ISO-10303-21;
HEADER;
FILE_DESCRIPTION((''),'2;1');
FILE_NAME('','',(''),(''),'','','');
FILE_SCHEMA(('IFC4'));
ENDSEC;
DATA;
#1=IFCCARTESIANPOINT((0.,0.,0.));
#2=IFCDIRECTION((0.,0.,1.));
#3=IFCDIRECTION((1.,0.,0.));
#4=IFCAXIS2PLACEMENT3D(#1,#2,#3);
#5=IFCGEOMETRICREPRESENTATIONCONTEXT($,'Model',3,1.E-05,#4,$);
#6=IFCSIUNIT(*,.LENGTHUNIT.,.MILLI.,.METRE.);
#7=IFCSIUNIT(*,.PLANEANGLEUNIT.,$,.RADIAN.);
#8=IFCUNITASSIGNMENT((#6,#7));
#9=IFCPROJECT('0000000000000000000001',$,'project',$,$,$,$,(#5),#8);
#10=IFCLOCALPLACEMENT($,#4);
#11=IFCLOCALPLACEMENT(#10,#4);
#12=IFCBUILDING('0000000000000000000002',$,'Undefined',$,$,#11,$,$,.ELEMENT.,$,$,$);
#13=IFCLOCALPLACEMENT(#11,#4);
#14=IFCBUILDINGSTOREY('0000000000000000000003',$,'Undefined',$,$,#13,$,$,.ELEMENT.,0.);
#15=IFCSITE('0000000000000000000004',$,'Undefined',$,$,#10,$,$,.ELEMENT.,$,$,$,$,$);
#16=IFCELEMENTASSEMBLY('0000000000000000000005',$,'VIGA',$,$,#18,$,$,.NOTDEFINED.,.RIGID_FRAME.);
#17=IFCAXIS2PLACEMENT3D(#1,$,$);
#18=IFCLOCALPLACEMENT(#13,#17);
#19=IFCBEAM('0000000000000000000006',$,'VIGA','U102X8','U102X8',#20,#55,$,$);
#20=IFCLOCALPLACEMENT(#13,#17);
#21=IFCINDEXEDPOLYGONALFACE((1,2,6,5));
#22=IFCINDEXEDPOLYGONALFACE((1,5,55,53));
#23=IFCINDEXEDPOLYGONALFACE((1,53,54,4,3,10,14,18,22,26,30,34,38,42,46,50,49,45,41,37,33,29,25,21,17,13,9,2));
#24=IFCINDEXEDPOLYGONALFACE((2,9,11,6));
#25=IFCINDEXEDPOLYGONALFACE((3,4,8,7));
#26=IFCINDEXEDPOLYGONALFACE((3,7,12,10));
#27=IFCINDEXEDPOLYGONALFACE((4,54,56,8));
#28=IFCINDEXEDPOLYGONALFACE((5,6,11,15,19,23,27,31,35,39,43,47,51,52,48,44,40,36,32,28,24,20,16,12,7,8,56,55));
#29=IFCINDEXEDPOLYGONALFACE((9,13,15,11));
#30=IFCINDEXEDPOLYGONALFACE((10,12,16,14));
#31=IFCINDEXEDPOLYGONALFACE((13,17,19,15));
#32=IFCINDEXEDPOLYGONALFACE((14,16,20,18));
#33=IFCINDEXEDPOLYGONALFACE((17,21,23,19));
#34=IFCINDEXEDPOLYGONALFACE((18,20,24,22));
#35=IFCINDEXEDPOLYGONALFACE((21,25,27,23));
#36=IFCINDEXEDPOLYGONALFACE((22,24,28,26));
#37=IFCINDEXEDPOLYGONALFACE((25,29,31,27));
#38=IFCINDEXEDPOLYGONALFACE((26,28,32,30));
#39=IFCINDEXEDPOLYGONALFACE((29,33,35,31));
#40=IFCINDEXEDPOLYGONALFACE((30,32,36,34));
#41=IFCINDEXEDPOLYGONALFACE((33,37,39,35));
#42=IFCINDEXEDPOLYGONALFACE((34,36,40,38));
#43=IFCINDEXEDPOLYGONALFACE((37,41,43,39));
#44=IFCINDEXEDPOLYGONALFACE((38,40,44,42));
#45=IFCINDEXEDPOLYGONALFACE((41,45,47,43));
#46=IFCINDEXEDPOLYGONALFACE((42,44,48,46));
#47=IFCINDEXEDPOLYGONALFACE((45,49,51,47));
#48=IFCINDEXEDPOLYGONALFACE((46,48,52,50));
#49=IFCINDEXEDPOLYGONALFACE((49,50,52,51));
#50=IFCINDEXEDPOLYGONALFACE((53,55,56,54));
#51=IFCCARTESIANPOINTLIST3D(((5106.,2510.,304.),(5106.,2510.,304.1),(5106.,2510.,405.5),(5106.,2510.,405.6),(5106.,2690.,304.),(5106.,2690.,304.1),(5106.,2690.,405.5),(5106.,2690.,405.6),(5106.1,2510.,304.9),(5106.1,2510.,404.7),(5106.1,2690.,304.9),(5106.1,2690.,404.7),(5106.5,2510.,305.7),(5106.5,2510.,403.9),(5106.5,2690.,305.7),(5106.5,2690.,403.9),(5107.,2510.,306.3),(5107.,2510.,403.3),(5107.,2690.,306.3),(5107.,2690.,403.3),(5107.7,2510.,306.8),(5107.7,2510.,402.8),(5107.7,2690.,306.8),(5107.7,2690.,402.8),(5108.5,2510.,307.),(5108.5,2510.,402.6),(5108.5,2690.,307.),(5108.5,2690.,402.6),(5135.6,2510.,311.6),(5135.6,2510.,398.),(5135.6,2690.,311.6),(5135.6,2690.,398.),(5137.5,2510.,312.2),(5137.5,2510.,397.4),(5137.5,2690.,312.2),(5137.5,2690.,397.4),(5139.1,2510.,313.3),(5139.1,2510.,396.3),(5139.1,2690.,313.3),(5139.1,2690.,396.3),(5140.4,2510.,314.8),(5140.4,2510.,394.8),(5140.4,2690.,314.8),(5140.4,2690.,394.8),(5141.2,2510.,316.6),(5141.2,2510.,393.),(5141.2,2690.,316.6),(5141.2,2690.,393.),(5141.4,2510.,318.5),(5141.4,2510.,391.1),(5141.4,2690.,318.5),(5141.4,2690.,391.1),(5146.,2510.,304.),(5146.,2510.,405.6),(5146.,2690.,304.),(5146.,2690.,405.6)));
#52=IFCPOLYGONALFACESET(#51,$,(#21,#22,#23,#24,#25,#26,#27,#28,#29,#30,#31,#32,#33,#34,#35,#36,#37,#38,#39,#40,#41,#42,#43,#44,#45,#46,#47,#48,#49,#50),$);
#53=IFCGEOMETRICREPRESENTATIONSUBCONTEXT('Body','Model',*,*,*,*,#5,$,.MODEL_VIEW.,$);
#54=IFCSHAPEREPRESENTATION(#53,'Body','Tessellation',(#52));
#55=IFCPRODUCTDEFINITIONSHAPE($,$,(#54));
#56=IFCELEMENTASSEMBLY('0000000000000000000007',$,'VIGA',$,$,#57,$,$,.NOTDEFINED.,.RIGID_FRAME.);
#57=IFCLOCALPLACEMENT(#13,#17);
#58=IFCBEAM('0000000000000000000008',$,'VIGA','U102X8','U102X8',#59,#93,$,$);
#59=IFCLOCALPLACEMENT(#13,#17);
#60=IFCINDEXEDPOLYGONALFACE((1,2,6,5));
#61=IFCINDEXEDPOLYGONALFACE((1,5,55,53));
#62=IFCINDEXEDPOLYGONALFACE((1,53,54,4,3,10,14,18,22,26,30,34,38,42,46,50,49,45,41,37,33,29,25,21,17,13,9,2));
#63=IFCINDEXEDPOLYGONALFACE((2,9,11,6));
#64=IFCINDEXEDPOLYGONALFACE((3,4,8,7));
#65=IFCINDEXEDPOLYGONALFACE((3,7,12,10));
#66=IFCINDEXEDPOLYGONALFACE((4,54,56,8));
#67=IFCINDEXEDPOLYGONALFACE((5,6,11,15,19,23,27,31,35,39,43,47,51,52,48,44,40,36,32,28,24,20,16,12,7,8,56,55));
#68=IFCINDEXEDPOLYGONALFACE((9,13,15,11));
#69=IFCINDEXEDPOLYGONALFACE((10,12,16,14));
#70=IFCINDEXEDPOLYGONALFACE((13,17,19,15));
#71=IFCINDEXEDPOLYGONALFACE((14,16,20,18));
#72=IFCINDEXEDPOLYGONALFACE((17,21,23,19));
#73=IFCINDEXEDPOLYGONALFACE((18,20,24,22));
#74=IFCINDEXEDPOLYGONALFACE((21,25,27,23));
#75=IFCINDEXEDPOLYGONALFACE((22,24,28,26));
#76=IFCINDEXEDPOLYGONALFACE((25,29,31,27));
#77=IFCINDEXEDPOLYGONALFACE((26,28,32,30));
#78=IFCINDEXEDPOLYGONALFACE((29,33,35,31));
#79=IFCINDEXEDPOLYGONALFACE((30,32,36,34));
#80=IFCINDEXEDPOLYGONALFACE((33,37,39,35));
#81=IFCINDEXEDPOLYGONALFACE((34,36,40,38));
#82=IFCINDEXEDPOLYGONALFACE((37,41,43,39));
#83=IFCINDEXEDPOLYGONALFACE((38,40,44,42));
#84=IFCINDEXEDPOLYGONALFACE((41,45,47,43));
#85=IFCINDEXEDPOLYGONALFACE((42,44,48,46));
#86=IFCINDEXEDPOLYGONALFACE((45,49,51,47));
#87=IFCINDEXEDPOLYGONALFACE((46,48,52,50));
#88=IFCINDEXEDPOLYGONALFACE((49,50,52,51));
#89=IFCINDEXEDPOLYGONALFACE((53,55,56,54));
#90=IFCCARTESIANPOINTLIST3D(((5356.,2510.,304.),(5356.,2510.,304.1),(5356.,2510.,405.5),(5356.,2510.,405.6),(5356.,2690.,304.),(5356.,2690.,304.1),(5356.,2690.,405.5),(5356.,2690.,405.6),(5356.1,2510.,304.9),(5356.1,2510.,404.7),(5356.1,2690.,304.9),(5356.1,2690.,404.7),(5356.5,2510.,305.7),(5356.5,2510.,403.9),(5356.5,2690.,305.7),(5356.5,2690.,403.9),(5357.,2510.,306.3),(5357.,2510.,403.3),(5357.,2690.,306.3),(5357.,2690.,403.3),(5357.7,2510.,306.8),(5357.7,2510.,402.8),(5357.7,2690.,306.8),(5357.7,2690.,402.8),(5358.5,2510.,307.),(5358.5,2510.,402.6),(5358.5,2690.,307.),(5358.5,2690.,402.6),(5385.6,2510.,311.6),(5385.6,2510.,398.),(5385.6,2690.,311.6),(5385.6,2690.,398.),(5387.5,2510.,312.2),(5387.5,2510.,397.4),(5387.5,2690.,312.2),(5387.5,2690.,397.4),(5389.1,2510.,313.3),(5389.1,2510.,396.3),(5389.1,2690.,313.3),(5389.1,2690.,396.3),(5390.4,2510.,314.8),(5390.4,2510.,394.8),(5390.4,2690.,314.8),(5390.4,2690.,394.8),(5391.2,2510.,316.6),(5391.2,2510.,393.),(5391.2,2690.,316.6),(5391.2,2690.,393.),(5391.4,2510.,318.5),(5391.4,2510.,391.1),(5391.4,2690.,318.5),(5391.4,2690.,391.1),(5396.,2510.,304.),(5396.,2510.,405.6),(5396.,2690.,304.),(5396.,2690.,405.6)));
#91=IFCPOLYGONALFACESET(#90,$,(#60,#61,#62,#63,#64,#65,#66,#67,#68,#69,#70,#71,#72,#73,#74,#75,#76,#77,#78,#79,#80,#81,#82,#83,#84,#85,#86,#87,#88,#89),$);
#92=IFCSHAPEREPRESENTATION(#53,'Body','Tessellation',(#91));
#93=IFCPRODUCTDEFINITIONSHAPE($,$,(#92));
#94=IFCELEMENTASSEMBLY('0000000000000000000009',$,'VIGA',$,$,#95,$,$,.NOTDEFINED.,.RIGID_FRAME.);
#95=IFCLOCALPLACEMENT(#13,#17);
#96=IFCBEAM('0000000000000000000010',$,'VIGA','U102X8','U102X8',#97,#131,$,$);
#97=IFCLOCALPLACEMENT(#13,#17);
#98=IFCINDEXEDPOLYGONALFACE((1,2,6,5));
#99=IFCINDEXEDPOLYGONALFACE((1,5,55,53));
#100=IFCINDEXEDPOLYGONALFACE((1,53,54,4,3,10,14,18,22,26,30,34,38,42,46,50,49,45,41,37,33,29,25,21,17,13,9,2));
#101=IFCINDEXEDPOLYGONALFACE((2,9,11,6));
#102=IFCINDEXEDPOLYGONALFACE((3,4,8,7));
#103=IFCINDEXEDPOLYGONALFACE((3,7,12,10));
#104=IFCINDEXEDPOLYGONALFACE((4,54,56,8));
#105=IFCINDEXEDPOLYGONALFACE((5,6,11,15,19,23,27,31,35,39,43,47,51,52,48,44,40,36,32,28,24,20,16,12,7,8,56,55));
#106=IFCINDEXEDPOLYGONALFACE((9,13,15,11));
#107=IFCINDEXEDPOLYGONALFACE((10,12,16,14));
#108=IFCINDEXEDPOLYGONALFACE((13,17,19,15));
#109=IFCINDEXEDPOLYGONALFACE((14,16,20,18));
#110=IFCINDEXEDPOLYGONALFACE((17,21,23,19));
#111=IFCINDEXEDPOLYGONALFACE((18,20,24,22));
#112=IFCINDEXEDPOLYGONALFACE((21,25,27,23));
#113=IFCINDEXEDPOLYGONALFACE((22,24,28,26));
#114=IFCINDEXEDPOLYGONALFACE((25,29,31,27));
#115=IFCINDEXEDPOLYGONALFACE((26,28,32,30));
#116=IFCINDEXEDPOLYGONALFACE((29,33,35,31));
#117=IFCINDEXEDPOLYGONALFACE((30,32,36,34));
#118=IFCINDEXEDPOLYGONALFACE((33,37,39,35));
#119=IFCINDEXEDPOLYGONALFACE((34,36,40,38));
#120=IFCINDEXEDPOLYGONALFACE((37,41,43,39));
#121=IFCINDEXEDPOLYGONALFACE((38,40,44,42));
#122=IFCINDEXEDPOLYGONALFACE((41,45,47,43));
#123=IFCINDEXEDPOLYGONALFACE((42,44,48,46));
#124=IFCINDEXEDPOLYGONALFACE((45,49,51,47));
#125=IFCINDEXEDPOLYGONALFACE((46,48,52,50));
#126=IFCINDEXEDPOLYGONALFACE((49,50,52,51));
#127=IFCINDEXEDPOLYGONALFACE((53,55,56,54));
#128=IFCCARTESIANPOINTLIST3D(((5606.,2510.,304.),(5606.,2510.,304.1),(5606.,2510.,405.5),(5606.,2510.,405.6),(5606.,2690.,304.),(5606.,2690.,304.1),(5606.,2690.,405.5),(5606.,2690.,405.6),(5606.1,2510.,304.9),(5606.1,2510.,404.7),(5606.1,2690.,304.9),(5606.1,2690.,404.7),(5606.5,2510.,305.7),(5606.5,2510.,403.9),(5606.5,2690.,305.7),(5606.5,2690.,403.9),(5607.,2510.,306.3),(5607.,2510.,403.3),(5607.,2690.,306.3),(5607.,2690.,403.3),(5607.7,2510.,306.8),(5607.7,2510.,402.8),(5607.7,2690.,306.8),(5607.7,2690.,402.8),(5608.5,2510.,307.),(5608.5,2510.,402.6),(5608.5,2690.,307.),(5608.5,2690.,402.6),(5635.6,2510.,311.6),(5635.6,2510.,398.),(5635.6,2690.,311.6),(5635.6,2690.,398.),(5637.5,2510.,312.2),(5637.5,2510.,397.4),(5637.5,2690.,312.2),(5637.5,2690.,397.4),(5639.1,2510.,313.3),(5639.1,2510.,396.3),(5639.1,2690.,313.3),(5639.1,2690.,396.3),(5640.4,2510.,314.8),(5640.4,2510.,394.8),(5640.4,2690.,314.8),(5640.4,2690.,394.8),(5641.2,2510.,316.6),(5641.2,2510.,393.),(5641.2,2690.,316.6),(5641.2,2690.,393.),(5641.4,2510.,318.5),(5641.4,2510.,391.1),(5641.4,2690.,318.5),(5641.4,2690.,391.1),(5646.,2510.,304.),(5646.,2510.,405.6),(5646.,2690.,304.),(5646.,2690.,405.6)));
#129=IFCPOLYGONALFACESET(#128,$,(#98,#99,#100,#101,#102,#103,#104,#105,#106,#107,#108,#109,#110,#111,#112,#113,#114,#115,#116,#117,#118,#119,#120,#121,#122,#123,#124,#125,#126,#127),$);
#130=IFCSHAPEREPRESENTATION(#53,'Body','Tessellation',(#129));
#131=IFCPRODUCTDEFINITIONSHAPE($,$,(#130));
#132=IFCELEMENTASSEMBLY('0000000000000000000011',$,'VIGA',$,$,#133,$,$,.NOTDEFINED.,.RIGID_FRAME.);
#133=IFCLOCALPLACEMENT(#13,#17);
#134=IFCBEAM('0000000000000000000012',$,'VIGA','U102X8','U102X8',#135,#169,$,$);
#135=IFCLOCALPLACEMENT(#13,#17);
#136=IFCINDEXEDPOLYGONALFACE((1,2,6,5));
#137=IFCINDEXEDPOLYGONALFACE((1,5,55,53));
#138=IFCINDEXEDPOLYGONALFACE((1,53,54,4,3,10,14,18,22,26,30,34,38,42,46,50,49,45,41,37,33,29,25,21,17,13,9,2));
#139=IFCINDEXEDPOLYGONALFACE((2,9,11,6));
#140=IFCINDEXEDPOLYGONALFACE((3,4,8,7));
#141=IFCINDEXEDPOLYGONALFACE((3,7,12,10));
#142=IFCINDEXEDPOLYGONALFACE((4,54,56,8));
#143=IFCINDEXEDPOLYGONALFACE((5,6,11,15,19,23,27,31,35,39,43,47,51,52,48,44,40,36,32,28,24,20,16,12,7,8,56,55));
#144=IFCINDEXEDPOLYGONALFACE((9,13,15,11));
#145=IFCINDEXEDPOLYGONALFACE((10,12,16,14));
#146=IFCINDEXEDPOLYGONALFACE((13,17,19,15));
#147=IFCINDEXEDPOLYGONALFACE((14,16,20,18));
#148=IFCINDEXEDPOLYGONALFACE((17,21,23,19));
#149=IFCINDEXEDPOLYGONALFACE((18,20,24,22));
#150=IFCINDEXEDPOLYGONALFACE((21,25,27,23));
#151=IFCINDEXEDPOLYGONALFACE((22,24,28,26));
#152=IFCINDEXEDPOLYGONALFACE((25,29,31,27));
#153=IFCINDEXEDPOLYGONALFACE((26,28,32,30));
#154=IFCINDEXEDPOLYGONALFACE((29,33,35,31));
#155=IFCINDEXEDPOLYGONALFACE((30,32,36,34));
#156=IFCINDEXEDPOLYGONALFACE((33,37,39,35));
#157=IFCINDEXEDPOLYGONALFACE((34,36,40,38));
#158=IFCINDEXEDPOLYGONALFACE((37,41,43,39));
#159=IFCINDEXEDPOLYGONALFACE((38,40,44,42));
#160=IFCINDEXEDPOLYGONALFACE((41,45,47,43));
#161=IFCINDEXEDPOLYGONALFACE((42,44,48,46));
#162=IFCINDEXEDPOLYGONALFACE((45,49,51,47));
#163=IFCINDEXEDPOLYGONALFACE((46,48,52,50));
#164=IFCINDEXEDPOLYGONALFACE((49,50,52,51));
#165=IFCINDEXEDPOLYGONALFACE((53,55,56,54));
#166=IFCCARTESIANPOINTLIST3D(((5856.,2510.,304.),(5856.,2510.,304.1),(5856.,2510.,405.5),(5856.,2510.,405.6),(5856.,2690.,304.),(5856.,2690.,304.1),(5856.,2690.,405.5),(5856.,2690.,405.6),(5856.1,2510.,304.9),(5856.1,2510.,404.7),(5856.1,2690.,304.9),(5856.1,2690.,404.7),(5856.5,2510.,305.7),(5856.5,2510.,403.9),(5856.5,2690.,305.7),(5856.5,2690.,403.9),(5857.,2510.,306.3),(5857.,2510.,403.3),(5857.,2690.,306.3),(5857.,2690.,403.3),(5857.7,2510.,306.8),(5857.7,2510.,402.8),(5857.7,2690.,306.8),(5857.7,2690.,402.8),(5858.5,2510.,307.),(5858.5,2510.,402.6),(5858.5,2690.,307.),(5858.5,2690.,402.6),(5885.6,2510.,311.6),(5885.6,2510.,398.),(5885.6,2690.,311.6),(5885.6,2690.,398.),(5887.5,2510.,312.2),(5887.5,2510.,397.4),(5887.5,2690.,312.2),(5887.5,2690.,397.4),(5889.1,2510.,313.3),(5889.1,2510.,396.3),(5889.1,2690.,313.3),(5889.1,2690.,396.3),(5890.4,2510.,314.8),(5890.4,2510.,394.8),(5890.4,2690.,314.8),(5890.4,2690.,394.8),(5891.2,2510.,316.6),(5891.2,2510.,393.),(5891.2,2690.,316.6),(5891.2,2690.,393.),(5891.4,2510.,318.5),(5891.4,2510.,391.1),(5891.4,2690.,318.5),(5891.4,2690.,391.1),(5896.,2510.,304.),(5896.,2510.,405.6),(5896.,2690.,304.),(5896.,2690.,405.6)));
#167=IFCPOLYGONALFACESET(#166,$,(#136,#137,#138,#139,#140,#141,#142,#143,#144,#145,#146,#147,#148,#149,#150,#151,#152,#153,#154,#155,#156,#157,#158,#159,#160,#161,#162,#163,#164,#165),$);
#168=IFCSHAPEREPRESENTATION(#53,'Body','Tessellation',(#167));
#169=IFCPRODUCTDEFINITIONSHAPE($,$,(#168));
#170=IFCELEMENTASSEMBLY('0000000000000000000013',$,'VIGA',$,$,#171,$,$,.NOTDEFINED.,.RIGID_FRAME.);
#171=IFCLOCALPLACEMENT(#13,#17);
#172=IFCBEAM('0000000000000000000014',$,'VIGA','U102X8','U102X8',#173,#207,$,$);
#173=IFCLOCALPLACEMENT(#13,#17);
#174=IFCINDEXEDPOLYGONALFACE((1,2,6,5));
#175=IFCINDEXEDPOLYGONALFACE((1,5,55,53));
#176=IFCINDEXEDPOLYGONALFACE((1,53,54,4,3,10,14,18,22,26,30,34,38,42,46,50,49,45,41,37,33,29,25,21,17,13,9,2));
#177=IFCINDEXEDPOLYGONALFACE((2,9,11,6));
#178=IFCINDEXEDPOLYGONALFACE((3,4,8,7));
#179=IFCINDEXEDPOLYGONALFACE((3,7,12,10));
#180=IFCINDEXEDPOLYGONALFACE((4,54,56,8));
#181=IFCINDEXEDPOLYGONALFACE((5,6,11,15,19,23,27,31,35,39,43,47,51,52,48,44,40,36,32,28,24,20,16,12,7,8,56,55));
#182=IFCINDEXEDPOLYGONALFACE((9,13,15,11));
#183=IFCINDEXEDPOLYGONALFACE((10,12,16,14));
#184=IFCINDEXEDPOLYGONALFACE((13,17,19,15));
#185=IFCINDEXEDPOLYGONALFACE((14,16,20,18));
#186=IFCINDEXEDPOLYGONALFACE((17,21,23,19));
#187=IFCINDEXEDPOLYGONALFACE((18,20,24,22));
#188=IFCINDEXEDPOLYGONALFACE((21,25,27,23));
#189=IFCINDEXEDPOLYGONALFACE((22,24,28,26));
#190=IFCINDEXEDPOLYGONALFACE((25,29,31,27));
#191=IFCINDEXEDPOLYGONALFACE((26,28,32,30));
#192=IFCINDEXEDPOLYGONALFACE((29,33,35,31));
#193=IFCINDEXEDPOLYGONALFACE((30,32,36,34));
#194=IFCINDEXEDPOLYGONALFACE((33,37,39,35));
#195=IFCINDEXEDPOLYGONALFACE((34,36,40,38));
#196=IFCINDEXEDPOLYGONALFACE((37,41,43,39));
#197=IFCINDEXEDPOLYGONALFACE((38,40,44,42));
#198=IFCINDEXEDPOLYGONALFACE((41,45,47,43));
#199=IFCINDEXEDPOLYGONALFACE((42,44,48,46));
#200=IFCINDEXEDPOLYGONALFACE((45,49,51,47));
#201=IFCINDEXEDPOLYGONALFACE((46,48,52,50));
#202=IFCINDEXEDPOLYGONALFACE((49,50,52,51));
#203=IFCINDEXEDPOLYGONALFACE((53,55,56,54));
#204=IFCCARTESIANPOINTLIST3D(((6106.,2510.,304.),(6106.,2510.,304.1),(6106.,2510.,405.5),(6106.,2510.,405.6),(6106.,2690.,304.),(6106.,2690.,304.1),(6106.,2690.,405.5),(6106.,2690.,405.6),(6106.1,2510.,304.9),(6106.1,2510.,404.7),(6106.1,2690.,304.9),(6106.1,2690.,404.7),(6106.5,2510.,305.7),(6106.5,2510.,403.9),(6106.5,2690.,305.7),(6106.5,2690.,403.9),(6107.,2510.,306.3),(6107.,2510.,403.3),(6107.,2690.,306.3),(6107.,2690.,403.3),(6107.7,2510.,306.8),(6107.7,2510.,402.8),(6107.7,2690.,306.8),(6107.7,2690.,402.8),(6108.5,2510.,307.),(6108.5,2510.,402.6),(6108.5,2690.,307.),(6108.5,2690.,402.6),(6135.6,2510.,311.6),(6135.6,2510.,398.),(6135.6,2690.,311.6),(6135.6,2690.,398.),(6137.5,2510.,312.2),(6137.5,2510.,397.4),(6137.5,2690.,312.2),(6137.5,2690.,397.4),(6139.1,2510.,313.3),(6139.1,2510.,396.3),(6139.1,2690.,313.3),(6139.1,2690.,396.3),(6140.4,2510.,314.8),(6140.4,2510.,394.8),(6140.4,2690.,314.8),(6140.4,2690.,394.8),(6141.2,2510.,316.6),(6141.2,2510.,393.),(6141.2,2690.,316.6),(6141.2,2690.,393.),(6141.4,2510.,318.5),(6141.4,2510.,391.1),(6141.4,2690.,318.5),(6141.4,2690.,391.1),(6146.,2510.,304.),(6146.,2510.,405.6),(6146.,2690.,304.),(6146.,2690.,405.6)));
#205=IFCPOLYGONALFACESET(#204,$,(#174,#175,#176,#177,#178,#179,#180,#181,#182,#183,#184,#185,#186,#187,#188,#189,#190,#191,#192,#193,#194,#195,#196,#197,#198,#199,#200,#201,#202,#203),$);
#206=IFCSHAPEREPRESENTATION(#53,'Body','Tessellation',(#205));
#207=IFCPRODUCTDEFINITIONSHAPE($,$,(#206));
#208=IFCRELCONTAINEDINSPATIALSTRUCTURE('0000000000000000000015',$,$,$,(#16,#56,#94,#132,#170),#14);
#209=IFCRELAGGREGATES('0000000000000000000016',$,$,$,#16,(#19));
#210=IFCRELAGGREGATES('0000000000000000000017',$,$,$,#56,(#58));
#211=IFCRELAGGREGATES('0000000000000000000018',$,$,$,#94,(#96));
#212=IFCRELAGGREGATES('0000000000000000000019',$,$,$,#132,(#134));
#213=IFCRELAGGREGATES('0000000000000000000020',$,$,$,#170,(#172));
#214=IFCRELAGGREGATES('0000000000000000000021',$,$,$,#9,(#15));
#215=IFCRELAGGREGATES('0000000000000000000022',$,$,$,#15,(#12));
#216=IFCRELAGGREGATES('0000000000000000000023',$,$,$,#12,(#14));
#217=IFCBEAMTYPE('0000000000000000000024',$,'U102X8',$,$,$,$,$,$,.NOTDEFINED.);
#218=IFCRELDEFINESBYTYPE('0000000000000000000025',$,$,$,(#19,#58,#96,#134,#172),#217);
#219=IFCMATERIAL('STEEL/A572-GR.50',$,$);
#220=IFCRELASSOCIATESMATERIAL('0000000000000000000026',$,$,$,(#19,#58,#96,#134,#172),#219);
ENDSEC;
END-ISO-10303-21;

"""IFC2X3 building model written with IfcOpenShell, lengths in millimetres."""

from ifc_helpers import new_model, si_unit, frame, origin_with_axes, origin_2d_with_axis, place, context, subcontext, project, spatial, u_section, extrude, material, type_object, element, aggregate, save


model = new_model("IFC2X3")

# Units and contexts
model_context = context("Model", 3, precision=1e-05, world=origin_with_axes())
body_context = subcontext(model_context, "Body", "Model", "MODEL_VIEW")
ifc_project = project(units=[si_unit("LENGTHUNIT", "METRE", prefix="MILLI"), si_unit("PLANEANGLEUNIT", "RADIAN")], contexts=[model_context])

# Site, building, storey
site_placement = place(None, origin_with_axes())
site = spatial("IfcSite", under=ifc_project, at=site_placement, Name="Undefined", CompositionType="ELEMENT")
building_placement = place(site_placement, origin_with_axes())
building = spatial("IfcBuilding", under=site, at=building_placement, Name="Undefined", CompositionType="ELEMENT")
storey_placement = place(building_placement, origin_with_axes())
storey = spatial("IfcBuildingStorey", under=building, at=storey_placement, Name="Undefined", CompositionType="ELEMENT", Elevation=0.0)

# Element assemblies, beams
assembly_1_placement = place(storey_placement, origin_with_axes())
assembly_1 = element("IfcElementAssembly", 1, at=assembly_1_placement, inside=storey, Name="VIGA", AssemblyPlace="NOTDEFINED", PredefinedType="RIGID_FRAME")
ifc_material_1 = material(Name="STEEL/A572-GR.50")
beam_type_1 = type_object("IfcBeamType", Name="U102X8", PredefinedType="NOTDEFINED")
beam_1_placement = place(assembly_1_placement, frame((5126.0, 2690.0, 354.8), z_axis=(0.0, 0.0, 1.0), x_axis=(0.0, -1.0, 0.0)))
beam_1 = element("IfcBeam", 2, at=beam_1_placement, type_object=beam_type_1, material=ifc_material_1, Name="VIGA", Description="U102X8", ObjectType="U102X8", context=body_context, shape_type="SweptSolid", body=[
    extrude(u_section(Depth=101.6, FlangeWidth=40.0, WebThickness=4.6, FlangeThickness=6.0, FilletRadius=7.0, EdgeRadius=3.0, FlangeSlope=0.16839, at=origin_2d_with_axis()), frame((180.0, 0.0, 0.0), z_axis=(-1.0, 0.0, 0.0), x_axis=(0.0, -1.0, 0.0)), (0.0, 0.0, 1.0), 180.0),
])
aggregate(assembly_1, [beam_1])
assembly_2_placement = place(storey_placement, origin_with_axes())
assembly_2 = element("IfcElementAssembly", 3, at=assembly_2_placement, inside=storey, Name="VIGA", AssemblyPlace="NOTDEFINED", PredefinedType="RIGID_FRAME")
beam_2_placement = place(assembly_2_placement, frame((5376.0, 2690.0, 354.8), z_axis=(0.0, 0.0, 1.0), x_axis=(0.0, -1.0, 0.0)))
beam_2 = element("IfcBeam", 4, at=beam_2_placement, type_object=beam_type_1, material=ifc_material_1, Name="VIGA", Description="U102X8", ObjectType="U102X8", context=body_context, shape_type="SweptSolid", body=[
    extrude(u_section(Depth=101.6, FlangeWidth=40.0, WebThickness=4.6, FlangeThickness=6.0, FilletRadius=7.0, EdgeRadius=3.0, FlangeSlope=0.16839, at=origin_2d_with_axis()), frame((180.0, 0.0, 0.0), z_axis=(-1.0, 0.0, 0.0), x_axis=(0.0, -1.0, 0.0)), (0.0, 0.0, 1.0), 180.0),
])
aggregate(assembly_2, [beam_2])
assembly_3_placement = place(storey_placement, origin_with_axes())
assembly_3 = element("IfcElementAssembly", 5, at=assembly_3_placement, inside=storey, Name="VIGA", AssemblyPlace="NOTDEFINED", PredefinedType="RIGID_FRAME")
beam_3_placement = place(assembly_3_placement, frame((5626.0, 2690.0, 354.8), z_axis=(0.0, 0.0, 1.0), x_axis=(0.0, -1.0, 0.0)))
beam_3 = element("IfcBeam", 6, at=beam_3_placement, type_object=beam_type_1, material=ifc_material_1, Name="VIGA", Description="U102X8", ObjectType="U102X8", context=body_context, shape_type="SweptSolid", body=[
    extrude(u_section(Depth=101.6, FlangeWidth=40.0, WebThickness=4.6, FlangeThickness=6.0, FilletRadius=7.0, EdgeRadius=3.0, FlangeSlope=0.16839, at=origin_2d_with_axis()), frame((180.0, 0.0, 0.0), z_axis=(-1.0, 0.0, 0.0), x_axis=(0.0, -1.0, 0.0)), (0.0, 0.0, 1.0), 180.0),
])
aggregate(assembly_3, [beam_3])
assembly_4_placement = place(storey_placement, origin_with_axes())
assembly_4 = element("IfcElementAssembly", 7, at=assembly_4_placement, inside=storey, Name="VIGA", AssemblyPlace="NOTDEFINED", PredefinedType="RIGID_FRAME")
beam_4_placement = place(assembly_4_placement, frame((5876.0, 2690.0, 354.8), z_axis=(0.0, 0.0, 1.0), x_axis=(0.0, -1.0, 0.0)))
beam_4 = element("IfcBeam", 8, at=beam_4_placement, type_object=beam_type_1, material=ifc_material_1, Name="VIGA", Description="U102X8", ObjectType="U102X8", context=body_context, shape_type="SweptSolid", body=[
    extrude(u_section(Depth=101.6, FlangeWidth=40.0, WebThickness=4.6, FlangeThickness=6.0, FilletRadius=7.0, EdgeRadius=3.0, FlangeSlope=0.16839, at=origin_2d_with_axis()), frame((180.0, 0.0, 0.0), z_axis=(-1.0, 0.0, 0.0), x_axis=(0.0, -1.0, 0.0)), (0.0, 0.0, 1.0), 180.0),
])
aggregate(assembly_4, [beam_4])
assembly_5_placement = place(storey_placement, origin_with_axes())
assembly_5 = element("IfcElementAssembly", 9, at=assembly_5_placement, inside=storey, Name="VIGA", AssemblyPlace="NOTDEFINED", PredefinedType="RIGID_FRAME")
beam_5_placement = place(assembly_5_placement, frame((6126.0, 2690.0, 354.8), z_axis=(0.0, 0.0, 1.0), x_axis=(0.0, -1.0, 0.0)))
beam_5 = element("IfcBeam", 10, at=beam_5_placement, type_object=beam_type_1, material=ifc_material_1, Name="VIGA", Description="U102X8", ObjectType="U102X8", context=body_context, shape_type="SweptSolid", body=[
    extrude(u_section(Depth=101.6, FlangeWidth=40.0, WebThickness=4.6, FlangeThickness=6.0, FilletRadius=7.0, EdgeRadius=3.0, FlangeSlope=0.16839, at=origin_2d_with_axis()), frame((180.0, 0.0, 0.0), z_axis=(-1.0, 0.0, 0.0), x_axis=(0.0, -1.0, 0.0)), (0.0, 0.0, 1.0), 180.0),
])
aggregate(assembly_5, [beam_5])

save(model, "model.ifc")
